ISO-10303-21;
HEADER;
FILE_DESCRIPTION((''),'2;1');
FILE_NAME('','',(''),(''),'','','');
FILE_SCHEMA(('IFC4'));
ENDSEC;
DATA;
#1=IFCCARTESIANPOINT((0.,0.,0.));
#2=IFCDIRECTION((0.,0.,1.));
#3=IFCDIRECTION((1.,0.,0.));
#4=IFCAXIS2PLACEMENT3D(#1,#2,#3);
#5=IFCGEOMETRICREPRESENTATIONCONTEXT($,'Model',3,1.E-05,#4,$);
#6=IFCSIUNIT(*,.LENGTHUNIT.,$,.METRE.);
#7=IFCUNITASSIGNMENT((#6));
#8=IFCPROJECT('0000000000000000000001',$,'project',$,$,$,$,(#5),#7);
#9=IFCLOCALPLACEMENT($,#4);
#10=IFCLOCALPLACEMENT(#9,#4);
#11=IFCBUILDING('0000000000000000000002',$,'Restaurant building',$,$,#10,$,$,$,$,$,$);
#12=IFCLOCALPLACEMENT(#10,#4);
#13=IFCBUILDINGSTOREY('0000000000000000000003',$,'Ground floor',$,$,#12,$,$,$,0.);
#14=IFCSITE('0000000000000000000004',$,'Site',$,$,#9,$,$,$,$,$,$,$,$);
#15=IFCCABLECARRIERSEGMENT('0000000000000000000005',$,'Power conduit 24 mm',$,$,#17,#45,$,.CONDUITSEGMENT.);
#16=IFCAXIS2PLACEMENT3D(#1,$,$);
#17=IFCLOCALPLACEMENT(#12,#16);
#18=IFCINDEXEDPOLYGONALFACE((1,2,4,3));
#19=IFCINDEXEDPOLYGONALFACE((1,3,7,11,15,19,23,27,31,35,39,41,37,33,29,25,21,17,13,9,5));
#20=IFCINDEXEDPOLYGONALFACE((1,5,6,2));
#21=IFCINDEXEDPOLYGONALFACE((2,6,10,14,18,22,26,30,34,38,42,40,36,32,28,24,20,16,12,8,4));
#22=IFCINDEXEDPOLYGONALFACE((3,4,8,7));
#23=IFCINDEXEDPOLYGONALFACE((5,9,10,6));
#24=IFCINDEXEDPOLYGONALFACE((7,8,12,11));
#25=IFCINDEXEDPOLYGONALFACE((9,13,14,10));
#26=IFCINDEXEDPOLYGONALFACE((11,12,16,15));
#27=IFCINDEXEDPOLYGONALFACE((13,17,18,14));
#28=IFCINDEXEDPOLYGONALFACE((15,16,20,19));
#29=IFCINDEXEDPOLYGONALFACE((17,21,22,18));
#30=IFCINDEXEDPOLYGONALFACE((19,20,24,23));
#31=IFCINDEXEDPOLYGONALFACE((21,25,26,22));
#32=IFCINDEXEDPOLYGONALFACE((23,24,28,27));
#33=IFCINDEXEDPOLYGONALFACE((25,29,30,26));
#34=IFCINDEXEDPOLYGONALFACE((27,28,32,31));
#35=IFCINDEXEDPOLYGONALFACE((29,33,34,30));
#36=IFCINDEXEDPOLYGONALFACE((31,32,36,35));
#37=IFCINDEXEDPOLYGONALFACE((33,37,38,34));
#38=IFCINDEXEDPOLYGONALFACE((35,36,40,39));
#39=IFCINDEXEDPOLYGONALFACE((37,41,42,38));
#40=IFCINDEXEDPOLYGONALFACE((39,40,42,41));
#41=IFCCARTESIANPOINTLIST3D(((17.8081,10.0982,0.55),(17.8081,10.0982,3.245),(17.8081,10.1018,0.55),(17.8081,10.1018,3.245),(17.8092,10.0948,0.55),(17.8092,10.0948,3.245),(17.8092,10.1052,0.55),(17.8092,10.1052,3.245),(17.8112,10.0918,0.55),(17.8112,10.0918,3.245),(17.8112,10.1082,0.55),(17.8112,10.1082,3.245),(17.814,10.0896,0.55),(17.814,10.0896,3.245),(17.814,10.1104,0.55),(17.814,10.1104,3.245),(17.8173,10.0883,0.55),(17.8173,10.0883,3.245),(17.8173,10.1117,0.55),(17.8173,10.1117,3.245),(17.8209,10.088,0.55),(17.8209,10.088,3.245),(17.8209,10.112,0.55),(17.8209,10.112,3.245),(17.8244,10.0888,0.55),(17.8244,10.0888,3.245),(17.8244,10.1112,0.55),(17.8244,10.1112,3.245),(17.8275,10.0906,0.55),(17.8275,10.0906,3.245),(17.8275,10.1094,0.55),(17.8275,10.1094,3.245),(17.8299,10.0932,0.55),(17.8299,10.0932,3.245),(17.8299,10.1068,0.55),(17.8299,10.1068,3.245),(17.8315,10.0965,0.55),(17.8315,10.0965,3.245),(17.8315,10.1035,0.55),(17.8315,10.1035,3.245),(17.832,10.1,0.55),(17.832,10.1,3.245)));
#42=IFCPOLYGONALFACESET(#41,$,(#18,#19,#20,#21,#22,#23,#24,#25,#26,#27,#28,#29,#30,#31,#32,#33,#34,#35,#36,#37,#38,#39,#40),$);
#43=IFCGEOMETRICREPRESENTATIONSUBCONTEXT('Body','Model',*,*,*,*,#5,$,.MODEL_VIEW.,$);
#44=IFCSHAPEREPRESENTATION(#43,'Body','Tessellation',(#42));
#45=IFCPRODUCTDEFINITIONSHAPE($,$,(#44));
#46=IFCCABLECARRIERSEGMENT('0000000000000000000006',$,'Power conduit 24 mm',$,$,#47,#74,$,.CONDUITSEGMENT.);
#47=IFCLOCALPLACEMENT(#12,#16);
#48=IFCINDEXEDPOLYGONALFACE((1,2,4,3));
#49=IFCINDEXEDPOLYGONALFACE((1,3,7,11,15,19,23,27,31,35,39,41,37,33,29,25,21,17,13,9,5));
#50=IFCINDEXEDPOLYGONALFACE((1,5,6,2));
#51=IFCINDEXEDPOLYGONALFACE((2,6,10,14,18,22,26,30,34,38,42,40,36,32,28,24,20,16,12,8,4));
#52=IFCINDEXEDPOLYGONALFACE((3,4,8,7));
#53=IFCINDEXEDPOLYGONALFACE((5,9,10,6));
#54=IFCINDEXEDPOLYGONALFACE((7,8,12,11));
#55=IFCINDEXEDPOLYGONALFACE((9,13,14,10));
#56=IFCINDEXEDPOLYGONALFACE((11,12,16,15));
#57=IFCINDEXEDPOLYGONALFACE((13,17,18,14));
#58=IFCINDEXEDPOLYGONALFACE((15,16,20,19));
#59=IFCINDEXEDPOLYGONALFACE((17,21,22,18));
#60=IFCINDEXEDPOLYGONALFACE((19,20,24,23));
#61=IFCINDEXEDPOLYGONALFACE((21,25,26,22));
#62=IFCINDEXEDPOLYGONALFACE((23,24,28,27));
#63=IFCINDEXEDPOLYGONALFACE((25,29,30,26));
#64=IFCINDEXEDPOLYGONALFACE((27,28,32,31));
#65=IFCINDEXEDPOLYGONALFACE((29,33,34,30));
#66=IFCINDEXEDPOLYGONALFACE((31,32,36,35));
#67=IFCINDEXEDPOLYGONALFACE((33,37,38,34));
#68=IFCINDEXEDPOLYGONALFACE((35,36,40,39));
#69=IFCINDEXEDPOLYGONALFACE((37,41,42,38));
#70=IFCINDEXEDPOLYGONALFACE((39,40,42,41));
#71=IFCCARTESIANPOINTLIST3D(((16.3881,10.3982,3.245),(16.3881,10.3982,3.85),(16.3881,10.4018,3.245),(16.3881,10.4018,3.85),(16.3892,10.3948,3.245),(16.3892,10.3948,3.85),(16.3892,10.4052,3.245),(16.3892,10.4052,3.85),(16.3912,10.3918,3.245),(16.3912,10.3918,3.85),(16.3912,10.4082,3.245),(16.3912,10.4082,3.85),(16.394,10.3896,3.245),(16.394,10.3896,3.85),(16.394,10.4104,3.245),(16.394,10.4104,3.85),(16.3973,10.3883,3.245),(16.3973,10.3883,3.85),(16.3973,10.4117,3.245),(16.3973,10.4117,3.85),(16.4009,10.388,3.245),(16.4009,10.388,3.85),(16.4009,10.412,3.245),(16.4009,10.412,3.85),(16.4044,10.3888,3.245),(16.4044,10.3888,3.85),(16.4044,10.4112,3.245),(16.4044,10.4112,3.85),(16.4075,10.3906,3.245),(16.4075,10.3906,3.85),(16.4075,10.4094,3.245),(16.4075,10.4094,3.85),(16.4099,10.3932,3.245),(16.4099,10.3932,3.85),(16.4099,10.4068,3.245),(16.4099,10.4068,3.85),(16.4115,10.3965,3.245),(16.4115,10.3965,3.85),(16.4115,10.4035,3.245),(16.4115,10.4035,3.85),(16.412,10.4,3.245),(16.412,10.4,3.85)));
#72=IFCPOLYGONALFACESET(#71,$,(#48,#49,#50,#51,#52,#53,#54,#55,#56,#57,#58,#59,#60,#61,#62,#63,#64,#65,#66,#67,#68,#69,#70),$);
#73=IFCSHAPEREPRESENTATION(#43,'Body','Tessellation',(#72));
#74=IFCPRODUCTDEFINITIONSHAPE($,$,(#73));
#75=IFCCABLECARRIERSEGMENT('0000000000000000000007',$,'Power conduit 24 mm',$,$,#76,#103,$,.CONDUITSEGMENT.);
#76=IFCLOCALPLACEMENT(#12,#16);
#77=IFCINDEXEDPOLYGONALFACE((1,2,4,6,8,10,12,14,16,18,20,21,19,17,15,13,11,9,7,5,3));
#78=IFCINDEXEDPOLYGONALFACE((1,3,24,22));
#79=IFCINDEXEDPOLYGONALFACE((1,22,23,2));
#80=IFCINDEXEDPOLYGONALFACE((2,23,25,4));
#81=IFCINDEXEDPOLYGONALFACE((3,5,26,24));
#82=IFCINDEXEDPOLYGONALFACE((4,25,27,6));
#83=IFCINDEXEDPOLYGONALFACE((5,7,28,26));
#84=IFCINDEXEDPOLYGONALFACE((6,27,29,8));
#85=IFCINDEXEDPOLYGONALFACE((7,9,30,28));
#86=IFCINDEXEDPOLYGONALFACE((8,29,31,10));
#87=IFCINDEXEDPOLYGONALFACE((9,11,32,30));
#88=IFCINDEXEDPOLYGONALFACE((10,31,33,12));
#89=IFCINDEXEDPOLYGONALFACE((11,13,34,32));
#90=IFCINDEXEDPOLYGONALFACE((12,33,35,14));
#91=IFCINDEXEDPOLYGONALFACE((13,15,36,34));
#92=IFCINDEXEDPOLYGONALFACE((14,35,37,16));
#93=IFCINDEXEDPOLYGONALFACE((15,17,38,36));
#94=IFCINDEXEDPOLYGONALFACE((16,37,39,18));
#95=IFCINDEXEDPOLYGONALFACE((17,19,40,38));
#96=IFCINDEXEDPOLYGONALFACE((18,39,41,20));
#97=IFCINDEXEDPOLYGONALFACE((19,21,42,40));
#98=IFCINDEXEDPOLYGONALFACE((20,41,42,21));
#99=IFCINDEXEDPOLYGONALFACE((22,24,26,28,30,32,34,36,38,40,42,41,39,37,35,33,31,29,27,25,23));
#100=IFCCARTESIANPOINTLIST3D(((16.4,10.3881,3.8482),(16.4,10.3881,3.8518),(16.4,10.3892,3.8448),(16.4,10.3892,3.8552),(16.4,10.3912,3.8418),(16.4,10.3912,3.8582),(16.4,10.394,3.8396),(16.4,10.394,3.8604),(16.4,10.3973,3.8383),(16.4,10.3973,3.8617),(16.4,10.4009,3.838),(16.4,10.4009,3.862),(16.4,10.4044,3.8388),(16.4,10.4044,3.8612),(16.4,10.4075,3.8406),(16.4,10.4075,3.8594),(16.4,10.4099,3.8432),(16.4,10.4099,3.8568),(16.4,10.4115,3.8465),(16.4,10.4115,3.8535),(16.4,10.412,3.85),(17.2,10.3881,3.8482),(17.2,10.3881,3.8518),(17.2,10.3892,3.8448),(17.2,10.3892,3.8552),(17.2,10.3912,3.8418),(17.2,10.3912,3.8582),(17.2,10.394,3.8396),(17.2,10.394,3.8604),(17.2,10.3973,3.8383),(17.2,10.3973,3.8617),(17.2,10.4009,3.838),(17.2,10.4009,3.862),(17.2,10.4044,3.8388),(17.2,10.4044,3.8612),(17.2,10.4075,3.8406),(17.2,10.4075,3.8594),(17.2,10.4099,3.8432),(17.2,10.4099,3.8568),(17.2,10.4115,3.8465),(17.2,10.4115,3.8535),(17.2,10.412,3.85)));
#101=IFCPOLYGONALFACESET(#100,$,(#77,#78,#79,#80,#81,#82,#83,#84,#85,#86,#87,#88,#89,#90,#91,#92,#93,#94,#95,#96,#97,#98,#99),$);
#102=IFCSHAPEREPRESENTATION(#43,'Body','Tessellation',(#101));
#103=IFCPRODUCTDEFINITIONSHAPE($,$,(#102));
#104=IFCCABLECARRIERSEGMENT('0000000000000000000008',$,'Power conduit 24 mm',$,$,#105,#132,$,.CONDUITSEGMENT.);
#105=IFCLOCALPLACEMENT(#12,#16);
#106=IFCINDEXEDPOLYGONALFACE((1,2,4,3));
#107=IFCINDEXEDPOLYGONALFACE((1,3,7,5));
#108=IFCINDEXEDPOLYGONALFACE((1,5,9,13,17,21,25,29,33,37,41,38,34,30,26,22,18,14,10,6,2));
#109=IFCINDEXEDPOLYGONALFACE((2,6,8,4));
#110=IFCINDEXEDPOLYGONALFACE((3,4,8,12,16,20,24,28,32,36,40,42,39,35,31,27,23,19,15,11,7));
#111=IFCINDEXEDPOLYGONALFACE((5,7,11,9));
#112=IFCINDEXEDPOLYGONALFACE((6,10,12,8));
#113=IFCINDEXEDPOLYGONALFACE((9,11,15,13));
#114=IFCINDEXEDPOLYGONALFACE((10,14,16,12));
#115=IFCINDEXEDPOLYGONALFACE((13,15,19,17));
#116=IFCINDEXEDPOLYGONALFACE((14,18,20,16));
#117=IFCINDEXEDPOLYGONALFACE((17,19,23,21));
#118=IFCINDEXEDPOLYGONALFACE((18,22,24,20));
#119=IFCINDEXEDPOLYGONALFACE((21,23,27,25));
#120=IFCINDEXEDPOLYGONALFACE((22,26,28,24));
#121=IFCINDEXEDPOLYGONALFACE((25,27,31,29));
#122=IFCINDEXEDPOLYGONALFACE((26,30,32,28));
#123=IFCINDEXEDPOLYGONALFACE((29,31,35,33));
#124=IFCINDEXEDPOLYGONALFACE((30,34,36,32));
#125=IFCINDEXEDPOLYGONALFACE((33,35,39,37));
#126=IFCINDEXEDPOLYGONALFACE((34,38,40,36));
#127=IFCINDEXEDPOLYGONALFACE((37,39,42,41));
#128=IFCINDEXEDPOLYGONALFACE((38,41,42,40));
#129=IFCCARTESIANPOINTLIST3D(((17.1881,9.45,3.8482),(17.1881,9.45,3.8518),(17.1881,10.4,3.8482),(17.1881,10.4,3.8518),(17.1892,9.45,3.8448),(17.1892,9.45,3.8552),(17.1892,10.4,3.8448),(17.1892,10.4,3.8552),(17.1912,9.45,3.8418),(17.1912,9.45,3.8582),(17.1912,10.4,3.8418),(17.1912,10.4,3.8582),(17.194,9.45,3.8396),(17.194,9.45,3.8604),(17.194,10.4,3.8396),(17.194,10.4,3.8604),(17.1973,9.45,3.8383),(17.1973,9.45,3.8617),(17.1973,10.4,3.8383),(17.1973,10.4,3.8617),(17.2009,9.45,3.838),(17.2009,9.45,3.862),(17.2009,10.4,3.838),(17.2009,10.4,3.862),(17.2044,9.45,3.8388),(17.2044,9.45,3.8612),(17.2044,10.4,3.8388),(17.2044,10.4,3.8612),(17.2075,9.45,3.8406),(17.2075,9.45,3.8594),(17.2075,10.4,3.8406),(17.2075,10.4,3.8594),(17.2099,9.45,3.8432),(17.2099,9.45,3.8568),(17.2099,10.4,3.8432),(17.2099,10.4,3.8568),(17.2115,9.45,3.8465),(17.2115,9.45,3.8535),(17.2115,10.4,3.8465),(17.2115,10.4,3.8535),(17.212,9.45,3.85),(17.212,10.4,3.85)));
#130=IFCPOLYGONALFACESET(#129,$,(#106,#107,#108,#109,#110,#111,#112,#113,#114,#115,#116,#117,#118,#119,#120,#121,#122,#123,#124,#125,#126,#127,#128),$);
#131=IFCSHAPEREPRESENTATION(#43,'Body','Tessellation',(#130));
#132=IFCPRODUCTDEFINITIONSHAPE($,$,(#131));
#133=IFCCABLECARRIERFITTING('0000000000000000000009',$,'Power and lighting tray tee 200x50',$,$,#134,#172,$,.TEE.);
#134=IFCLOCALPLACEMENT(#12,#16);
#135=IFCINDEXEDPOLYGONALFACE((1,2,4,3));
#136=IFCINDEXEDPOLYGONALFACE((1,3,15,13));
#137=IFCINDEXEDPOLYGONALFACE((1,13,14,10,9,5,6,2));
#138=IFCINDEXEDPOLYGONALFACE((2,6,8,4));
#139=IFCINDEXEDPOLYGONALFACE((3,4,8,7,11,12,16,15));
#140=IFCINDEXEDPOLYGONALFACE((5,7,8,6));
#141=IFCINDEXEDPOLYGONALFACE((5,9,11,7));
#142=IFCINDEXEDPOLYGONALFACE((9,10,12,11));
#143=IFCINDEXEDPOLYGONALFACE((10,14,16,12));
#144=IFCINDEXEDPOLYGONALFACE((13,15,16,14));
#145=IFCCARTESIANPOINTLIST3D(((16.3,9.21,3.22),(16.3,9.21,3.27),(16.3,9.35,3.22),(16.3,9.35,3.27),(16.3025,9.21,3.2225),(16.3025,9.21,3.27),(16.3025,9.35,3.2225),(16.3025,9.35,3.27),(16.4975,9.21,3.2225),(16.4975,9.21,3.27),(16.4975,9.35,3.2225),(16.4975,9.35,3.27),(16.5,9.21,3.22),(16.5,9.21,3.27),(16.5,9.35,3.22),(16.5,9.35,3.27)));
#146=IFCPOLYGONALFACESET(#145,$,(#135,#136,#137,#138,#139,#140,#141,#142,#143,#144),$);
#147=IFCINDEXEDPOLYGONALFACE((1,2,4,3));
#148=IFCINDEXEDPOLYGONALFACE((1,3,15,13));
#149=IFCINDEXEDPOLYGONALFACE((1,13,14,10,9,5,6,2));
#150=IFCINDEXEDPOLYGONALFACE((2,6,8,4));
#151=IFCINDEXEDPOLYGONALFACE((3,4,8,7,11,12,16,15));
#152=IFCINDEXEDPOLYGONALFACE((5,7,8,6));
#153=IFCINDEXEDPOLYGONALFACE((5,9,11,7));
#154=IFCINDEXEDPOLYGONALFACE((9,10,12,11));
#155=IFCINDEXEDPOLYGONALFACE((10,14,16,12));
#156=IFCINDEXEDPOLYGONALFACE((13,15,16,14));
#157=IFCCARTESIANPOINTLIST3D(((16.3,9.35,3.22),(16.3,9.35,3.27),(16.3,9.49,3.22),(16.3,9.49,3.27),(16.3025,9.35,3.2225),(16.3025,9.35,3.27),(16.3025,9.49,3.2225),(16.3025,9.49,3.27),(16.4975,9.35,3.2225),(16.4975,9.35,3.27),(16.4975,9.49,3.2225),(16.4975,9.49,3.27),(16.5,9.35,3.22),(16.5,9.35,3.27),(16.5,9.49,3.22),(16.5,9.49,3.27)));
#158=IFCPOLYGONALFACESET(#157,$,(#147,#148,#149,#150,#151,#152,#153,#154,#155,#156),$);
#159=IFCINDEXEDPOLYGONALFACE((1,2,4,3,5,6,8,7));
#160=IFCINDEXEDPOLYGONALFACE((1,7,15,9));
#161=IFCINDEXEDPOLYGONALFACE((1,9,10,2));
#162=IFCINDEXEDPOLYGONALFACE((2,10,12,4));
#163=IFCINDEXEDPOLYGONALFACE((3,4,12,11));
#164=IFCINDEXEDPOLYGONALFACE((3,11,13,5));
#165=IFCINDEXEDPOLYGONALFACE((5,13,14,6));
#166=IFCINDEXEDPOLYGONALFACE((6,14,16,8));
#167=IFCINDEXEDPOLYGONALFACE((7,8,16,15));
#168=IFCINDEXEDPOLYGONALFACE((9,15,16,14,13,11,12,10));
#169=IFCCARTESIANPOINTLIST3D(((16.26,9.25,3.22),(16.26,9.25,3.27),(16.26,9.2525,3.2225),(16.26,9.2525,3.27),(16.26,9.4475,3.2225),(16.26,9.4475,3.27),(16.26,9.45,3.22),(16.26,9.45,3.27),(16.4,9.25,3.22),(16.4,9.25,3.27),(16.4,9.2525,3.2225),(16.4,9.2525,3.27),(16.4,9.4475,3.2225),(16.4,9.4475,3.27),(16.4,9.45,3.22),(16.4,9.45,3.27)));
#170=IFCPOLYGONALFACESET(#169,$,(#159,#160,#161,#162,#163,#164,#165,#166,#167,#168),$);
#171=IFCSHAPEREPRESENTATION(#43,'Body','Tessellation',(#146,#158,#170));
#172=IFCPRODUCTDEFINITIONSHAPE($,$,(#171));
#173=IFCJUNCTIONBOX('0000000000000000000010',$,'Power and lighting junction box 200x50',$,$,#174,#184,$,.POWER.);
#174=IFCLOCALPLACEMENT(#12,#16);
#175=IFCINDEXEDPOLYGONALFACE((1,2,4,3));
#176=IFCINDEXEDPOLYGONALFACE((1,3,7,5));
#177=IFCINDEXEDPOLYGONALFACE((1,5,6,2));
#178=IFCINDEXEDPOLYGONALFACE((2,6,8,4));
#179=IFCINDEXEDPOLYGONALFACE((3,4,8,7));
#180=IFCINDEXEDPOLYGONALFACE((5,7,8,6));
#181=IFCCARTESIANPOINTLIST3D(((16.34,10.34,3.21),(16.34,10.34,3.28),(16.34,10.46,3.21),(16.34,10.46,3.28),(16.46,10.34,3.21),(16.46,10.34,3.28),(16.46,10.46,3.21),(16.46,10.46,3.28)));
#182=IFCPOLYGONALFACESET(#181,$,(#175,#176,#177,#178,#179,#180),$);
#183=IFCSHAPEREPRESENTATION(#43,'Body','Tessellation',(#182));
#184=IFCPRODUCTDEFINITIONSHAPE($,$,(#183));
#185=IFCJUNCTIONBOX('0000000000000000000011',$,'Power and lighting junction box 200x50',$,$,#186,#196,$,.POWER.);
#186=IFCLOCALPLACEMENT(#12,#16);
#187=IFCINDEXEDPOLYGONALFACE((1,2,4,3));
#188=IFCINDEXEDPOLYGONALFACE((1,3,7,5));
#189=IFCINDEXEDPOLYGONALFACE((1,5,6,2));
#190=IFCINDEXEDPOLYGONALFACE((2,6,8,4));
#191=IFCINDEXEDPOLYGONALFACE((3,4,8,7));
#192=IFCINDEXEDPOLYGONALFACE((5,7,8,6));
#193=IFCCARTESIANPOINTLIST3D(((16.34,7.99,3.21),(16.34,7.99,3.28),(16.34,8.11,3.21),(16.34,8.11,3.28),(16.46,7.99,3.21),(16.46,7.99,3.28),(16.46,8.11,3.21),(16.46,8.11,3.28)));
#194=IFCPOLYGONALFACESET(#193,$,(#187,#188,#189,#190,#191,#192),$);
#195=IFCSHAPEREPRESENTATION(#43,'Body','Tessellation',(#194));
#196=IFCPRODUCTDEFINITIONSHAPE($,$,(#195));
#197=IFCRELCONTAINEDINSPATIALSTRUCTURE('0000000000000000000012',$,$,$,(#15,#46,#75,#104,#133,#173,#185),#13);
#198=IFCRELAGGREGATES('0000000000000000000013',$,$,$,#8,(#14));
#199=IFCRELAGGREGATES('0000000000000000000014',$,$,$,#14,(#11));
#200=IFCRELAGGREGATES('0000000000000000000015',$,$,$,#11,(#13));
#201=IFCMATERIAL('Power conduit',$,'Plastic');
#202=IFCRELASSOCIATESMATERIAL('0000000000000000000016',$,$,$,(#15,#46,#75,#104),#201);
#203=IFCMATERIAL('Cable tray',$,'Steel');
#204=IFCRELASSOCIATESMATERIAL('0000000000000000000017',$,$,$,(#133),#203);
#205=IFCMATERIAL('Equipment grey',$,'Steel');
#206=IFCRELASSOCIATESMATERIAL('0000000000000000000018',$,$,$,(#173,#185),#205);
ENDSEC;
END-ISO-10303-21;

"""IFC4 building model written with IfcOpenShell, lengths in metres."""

from ifc_helpers import new_model, si_unit, frame, origin, origin_with_axes, origin_2d, place, context, subcontext, project, spatial, polyline, rectangle, circle, outline, extrude, material, element, save


model = new_model("IFC4")

# Units and contexts
model_context = context("Model", 3, precision=1e-05, world=origin_with_axes())
body_context = subcontext(model_context, "Body", "Model", "MODEL_VIEW")
ifc_project = project(units=[si_unit("LENGTHUNIT", "METRE")], contexts=[model_context])

# Site, building, storey
site_placement = place(None, origin_with_axes())
site = spatial("IfcSite", under=ifc_project, at=site_placement, Name="Site")
building_placement = place(site_placement, origin_with_axes())
building = spatial("IfcBuilding", under=site, at=building_placement, Name="Restaurant building")
storey_placement = place(building_placement, origin_with_axes())
storey = spatial("IfcBuildingStorey", under=building, at=storey_placement, Name="Ground floor", Elevation=0.0)

# Cable carrier segments
ifc_material_1 = material(Name="Cable tray", Category="Steel")
ifc_material_2 = material(Name="Power conduit", Category="Plastic")
cable_carrier_segment_1_placement = place(storey_placement, frame((17.82, 10.1, 3.245)))
element("IfcCableCarrierSegment", 1, at=cable_carrier_segment_1_placement, inside=storey, material=ifc_material_2, Name="Power conduit 24 mm", PredefinedType="CONDUITSEGMENT", context=body_context, shape_type="SweptSolid", body=[
    extrude(circle(Radius=0.012, at=origin_2d()), frame((0.0, 0.0, 0.0), z_axis=(0.0, 0.0, -1.0), x_axis=(1.0, 0.0, 0.0)), (0.0, 0.0, 1.0), 2.695),
])
cable_carrier_segment_2_placement = place(storey_placement, frame((16.4, 10.4, 3.245)))
element("IfcCableCarrierSegment", 2, at=cable_carrier_segment_2_placement, inside=storey, material=ifc_material_2, Name="Power conduit 24 mm", PredefinedType="CONDUITSEGMENT", context=body_context, shape_type="SweptSolid", body=[
    extrude(circle(Radius=0.012, at=origin_2d()), origin(), (0.0, 0.0, 1.0), 0.605),
])
cable_carrier_segment_3_placement = place(storey_placement, frame((16.4, 10.4, 3.85)))
element("IfcCableCarrierSegment", 3, at=cable_carrier_segment_3_placement, inside=storey, material=ifc_material_2, Name="Power conduit 24 mm", PredefinedType="CONDUITSEGMENT", context=body_context, shape_type="SweptSolid", body=[
    extrude(circle(Radius=0.012, at=origin_2d()), frame((0.0, 0.0, 0.0), z_axis=(1.0, 0.0, 0.0), x_axis=(0.0, 1.0, 0.0)), (0.0, 0.0, 1.0), 0.8),
])
cable_carrier_segment_4_placement = place(storey_placement, frame((17.2, 10.4, 3.85)))
element("IfcCableCarrierSegment", 4, at=cable_carrier_segment_4_placement, inside=storey, material=ifc_material_2, Name="Power conduit 24 mm", PredefinedType="CONDUITSEGMENT", context=body_context, shape_type="SweptSolid", body=[
    extrude(circle(Radius=0.012, at=origin_2d()), frame((0.0, 0.0, 0.0), z_axis=(0.0, -1.0, 0.0), x_axis=(1.0, 0.0, 0.0)), (0.0, 0.0, 1.0), 0.95),
])

# Cable carrier fitting
cable_carrier_fitting_1_placement = place(storey_placement, frame((16.4, 9.35, 3.245)))
element("IfcCableCarrierFitting", 5, at=cable_carrier_fitting_1_placement, inside=storey, material=ifc_material_1, Name="Power and lighting tray tee 200x50", PredefinedType="TEE", context=body_context, shape_type="SweptSolid", body=[
    extrude(outline(polyline([(-0.1, -0.025), (0.1, -0.025), (0.1, 0.025), (0.0975, 0.025), (0.0975, -0.0225), (-0.0975, -0.0225), (-0.0975, 0.025), (-0.1, 0.025), (-0.1, -0.025)])), frame((0.0, 0.0, 0.0), z_axis=(0.0, -1.0, 0.0), x_axis=(1.0, 0.0, 0.0)), (0.0, 0.0, 1.0), 0.14),
    extrude(outline(polyline([(-0.1, -0.025), (0.1, -0.025), (0.1, 0.025), (0.0975, 0.025), (0.0975, -0.0225), (-0.0975, -0.0225), (-0.0975, 0.025), (-0.1, 0.025), (-0.1, -0.025)])), frame((0.0, 0.0, 0.0), z_axis=(0.0, 1.0, 0.0), x_axis=(-1.0, 0.0, 0.0)), (0.0, 0.0, 1.0), 0.14),
    extrude(outline(polyline([(-0.1, -0.025), (0.1, -0.025), (0.1, 0.025), (0.0975, 0.025), (0.0975, -0.0225), (-0.0975, -0.0225), (-0.0975, 0.025), (-0.1, 0.025), (-0.1, -0.025)])), frame((0.0, 0.0, 0.0), z_axis=(-1.0, 0.0, 0.0), x_axis=(0.0, -1.0, 0.0)), (0.0, 0.0, 1.0), 0.14),
])

# Junction boxes
ifc_material_3 = material(Name="Equipment grey", Category="Steel")
for number, where, name in (
    (6, (16.4, 10.4, 3.245), "Power and lighting junction box 200x50"),
    (7, (16.4, 8.05, 3.245), "Power and lighting junction box 200x50"),
):
    element("IfcJunctionBox", number, at=place(storey_placement, frame(where)), inside=storey, material=ifc_material_3, Name=name, PredefinedType="POWER", context=body_context, shape_type="SweptSolid", body=[
        extrude(rectangle(XDim=0.12, YDim=0.12, at=origin_2d()), frame((0.0, 0.0, -0.035)), (0.0, 0.0, 1.0), 0.07),
    ])

save(model, "model.ifc")
